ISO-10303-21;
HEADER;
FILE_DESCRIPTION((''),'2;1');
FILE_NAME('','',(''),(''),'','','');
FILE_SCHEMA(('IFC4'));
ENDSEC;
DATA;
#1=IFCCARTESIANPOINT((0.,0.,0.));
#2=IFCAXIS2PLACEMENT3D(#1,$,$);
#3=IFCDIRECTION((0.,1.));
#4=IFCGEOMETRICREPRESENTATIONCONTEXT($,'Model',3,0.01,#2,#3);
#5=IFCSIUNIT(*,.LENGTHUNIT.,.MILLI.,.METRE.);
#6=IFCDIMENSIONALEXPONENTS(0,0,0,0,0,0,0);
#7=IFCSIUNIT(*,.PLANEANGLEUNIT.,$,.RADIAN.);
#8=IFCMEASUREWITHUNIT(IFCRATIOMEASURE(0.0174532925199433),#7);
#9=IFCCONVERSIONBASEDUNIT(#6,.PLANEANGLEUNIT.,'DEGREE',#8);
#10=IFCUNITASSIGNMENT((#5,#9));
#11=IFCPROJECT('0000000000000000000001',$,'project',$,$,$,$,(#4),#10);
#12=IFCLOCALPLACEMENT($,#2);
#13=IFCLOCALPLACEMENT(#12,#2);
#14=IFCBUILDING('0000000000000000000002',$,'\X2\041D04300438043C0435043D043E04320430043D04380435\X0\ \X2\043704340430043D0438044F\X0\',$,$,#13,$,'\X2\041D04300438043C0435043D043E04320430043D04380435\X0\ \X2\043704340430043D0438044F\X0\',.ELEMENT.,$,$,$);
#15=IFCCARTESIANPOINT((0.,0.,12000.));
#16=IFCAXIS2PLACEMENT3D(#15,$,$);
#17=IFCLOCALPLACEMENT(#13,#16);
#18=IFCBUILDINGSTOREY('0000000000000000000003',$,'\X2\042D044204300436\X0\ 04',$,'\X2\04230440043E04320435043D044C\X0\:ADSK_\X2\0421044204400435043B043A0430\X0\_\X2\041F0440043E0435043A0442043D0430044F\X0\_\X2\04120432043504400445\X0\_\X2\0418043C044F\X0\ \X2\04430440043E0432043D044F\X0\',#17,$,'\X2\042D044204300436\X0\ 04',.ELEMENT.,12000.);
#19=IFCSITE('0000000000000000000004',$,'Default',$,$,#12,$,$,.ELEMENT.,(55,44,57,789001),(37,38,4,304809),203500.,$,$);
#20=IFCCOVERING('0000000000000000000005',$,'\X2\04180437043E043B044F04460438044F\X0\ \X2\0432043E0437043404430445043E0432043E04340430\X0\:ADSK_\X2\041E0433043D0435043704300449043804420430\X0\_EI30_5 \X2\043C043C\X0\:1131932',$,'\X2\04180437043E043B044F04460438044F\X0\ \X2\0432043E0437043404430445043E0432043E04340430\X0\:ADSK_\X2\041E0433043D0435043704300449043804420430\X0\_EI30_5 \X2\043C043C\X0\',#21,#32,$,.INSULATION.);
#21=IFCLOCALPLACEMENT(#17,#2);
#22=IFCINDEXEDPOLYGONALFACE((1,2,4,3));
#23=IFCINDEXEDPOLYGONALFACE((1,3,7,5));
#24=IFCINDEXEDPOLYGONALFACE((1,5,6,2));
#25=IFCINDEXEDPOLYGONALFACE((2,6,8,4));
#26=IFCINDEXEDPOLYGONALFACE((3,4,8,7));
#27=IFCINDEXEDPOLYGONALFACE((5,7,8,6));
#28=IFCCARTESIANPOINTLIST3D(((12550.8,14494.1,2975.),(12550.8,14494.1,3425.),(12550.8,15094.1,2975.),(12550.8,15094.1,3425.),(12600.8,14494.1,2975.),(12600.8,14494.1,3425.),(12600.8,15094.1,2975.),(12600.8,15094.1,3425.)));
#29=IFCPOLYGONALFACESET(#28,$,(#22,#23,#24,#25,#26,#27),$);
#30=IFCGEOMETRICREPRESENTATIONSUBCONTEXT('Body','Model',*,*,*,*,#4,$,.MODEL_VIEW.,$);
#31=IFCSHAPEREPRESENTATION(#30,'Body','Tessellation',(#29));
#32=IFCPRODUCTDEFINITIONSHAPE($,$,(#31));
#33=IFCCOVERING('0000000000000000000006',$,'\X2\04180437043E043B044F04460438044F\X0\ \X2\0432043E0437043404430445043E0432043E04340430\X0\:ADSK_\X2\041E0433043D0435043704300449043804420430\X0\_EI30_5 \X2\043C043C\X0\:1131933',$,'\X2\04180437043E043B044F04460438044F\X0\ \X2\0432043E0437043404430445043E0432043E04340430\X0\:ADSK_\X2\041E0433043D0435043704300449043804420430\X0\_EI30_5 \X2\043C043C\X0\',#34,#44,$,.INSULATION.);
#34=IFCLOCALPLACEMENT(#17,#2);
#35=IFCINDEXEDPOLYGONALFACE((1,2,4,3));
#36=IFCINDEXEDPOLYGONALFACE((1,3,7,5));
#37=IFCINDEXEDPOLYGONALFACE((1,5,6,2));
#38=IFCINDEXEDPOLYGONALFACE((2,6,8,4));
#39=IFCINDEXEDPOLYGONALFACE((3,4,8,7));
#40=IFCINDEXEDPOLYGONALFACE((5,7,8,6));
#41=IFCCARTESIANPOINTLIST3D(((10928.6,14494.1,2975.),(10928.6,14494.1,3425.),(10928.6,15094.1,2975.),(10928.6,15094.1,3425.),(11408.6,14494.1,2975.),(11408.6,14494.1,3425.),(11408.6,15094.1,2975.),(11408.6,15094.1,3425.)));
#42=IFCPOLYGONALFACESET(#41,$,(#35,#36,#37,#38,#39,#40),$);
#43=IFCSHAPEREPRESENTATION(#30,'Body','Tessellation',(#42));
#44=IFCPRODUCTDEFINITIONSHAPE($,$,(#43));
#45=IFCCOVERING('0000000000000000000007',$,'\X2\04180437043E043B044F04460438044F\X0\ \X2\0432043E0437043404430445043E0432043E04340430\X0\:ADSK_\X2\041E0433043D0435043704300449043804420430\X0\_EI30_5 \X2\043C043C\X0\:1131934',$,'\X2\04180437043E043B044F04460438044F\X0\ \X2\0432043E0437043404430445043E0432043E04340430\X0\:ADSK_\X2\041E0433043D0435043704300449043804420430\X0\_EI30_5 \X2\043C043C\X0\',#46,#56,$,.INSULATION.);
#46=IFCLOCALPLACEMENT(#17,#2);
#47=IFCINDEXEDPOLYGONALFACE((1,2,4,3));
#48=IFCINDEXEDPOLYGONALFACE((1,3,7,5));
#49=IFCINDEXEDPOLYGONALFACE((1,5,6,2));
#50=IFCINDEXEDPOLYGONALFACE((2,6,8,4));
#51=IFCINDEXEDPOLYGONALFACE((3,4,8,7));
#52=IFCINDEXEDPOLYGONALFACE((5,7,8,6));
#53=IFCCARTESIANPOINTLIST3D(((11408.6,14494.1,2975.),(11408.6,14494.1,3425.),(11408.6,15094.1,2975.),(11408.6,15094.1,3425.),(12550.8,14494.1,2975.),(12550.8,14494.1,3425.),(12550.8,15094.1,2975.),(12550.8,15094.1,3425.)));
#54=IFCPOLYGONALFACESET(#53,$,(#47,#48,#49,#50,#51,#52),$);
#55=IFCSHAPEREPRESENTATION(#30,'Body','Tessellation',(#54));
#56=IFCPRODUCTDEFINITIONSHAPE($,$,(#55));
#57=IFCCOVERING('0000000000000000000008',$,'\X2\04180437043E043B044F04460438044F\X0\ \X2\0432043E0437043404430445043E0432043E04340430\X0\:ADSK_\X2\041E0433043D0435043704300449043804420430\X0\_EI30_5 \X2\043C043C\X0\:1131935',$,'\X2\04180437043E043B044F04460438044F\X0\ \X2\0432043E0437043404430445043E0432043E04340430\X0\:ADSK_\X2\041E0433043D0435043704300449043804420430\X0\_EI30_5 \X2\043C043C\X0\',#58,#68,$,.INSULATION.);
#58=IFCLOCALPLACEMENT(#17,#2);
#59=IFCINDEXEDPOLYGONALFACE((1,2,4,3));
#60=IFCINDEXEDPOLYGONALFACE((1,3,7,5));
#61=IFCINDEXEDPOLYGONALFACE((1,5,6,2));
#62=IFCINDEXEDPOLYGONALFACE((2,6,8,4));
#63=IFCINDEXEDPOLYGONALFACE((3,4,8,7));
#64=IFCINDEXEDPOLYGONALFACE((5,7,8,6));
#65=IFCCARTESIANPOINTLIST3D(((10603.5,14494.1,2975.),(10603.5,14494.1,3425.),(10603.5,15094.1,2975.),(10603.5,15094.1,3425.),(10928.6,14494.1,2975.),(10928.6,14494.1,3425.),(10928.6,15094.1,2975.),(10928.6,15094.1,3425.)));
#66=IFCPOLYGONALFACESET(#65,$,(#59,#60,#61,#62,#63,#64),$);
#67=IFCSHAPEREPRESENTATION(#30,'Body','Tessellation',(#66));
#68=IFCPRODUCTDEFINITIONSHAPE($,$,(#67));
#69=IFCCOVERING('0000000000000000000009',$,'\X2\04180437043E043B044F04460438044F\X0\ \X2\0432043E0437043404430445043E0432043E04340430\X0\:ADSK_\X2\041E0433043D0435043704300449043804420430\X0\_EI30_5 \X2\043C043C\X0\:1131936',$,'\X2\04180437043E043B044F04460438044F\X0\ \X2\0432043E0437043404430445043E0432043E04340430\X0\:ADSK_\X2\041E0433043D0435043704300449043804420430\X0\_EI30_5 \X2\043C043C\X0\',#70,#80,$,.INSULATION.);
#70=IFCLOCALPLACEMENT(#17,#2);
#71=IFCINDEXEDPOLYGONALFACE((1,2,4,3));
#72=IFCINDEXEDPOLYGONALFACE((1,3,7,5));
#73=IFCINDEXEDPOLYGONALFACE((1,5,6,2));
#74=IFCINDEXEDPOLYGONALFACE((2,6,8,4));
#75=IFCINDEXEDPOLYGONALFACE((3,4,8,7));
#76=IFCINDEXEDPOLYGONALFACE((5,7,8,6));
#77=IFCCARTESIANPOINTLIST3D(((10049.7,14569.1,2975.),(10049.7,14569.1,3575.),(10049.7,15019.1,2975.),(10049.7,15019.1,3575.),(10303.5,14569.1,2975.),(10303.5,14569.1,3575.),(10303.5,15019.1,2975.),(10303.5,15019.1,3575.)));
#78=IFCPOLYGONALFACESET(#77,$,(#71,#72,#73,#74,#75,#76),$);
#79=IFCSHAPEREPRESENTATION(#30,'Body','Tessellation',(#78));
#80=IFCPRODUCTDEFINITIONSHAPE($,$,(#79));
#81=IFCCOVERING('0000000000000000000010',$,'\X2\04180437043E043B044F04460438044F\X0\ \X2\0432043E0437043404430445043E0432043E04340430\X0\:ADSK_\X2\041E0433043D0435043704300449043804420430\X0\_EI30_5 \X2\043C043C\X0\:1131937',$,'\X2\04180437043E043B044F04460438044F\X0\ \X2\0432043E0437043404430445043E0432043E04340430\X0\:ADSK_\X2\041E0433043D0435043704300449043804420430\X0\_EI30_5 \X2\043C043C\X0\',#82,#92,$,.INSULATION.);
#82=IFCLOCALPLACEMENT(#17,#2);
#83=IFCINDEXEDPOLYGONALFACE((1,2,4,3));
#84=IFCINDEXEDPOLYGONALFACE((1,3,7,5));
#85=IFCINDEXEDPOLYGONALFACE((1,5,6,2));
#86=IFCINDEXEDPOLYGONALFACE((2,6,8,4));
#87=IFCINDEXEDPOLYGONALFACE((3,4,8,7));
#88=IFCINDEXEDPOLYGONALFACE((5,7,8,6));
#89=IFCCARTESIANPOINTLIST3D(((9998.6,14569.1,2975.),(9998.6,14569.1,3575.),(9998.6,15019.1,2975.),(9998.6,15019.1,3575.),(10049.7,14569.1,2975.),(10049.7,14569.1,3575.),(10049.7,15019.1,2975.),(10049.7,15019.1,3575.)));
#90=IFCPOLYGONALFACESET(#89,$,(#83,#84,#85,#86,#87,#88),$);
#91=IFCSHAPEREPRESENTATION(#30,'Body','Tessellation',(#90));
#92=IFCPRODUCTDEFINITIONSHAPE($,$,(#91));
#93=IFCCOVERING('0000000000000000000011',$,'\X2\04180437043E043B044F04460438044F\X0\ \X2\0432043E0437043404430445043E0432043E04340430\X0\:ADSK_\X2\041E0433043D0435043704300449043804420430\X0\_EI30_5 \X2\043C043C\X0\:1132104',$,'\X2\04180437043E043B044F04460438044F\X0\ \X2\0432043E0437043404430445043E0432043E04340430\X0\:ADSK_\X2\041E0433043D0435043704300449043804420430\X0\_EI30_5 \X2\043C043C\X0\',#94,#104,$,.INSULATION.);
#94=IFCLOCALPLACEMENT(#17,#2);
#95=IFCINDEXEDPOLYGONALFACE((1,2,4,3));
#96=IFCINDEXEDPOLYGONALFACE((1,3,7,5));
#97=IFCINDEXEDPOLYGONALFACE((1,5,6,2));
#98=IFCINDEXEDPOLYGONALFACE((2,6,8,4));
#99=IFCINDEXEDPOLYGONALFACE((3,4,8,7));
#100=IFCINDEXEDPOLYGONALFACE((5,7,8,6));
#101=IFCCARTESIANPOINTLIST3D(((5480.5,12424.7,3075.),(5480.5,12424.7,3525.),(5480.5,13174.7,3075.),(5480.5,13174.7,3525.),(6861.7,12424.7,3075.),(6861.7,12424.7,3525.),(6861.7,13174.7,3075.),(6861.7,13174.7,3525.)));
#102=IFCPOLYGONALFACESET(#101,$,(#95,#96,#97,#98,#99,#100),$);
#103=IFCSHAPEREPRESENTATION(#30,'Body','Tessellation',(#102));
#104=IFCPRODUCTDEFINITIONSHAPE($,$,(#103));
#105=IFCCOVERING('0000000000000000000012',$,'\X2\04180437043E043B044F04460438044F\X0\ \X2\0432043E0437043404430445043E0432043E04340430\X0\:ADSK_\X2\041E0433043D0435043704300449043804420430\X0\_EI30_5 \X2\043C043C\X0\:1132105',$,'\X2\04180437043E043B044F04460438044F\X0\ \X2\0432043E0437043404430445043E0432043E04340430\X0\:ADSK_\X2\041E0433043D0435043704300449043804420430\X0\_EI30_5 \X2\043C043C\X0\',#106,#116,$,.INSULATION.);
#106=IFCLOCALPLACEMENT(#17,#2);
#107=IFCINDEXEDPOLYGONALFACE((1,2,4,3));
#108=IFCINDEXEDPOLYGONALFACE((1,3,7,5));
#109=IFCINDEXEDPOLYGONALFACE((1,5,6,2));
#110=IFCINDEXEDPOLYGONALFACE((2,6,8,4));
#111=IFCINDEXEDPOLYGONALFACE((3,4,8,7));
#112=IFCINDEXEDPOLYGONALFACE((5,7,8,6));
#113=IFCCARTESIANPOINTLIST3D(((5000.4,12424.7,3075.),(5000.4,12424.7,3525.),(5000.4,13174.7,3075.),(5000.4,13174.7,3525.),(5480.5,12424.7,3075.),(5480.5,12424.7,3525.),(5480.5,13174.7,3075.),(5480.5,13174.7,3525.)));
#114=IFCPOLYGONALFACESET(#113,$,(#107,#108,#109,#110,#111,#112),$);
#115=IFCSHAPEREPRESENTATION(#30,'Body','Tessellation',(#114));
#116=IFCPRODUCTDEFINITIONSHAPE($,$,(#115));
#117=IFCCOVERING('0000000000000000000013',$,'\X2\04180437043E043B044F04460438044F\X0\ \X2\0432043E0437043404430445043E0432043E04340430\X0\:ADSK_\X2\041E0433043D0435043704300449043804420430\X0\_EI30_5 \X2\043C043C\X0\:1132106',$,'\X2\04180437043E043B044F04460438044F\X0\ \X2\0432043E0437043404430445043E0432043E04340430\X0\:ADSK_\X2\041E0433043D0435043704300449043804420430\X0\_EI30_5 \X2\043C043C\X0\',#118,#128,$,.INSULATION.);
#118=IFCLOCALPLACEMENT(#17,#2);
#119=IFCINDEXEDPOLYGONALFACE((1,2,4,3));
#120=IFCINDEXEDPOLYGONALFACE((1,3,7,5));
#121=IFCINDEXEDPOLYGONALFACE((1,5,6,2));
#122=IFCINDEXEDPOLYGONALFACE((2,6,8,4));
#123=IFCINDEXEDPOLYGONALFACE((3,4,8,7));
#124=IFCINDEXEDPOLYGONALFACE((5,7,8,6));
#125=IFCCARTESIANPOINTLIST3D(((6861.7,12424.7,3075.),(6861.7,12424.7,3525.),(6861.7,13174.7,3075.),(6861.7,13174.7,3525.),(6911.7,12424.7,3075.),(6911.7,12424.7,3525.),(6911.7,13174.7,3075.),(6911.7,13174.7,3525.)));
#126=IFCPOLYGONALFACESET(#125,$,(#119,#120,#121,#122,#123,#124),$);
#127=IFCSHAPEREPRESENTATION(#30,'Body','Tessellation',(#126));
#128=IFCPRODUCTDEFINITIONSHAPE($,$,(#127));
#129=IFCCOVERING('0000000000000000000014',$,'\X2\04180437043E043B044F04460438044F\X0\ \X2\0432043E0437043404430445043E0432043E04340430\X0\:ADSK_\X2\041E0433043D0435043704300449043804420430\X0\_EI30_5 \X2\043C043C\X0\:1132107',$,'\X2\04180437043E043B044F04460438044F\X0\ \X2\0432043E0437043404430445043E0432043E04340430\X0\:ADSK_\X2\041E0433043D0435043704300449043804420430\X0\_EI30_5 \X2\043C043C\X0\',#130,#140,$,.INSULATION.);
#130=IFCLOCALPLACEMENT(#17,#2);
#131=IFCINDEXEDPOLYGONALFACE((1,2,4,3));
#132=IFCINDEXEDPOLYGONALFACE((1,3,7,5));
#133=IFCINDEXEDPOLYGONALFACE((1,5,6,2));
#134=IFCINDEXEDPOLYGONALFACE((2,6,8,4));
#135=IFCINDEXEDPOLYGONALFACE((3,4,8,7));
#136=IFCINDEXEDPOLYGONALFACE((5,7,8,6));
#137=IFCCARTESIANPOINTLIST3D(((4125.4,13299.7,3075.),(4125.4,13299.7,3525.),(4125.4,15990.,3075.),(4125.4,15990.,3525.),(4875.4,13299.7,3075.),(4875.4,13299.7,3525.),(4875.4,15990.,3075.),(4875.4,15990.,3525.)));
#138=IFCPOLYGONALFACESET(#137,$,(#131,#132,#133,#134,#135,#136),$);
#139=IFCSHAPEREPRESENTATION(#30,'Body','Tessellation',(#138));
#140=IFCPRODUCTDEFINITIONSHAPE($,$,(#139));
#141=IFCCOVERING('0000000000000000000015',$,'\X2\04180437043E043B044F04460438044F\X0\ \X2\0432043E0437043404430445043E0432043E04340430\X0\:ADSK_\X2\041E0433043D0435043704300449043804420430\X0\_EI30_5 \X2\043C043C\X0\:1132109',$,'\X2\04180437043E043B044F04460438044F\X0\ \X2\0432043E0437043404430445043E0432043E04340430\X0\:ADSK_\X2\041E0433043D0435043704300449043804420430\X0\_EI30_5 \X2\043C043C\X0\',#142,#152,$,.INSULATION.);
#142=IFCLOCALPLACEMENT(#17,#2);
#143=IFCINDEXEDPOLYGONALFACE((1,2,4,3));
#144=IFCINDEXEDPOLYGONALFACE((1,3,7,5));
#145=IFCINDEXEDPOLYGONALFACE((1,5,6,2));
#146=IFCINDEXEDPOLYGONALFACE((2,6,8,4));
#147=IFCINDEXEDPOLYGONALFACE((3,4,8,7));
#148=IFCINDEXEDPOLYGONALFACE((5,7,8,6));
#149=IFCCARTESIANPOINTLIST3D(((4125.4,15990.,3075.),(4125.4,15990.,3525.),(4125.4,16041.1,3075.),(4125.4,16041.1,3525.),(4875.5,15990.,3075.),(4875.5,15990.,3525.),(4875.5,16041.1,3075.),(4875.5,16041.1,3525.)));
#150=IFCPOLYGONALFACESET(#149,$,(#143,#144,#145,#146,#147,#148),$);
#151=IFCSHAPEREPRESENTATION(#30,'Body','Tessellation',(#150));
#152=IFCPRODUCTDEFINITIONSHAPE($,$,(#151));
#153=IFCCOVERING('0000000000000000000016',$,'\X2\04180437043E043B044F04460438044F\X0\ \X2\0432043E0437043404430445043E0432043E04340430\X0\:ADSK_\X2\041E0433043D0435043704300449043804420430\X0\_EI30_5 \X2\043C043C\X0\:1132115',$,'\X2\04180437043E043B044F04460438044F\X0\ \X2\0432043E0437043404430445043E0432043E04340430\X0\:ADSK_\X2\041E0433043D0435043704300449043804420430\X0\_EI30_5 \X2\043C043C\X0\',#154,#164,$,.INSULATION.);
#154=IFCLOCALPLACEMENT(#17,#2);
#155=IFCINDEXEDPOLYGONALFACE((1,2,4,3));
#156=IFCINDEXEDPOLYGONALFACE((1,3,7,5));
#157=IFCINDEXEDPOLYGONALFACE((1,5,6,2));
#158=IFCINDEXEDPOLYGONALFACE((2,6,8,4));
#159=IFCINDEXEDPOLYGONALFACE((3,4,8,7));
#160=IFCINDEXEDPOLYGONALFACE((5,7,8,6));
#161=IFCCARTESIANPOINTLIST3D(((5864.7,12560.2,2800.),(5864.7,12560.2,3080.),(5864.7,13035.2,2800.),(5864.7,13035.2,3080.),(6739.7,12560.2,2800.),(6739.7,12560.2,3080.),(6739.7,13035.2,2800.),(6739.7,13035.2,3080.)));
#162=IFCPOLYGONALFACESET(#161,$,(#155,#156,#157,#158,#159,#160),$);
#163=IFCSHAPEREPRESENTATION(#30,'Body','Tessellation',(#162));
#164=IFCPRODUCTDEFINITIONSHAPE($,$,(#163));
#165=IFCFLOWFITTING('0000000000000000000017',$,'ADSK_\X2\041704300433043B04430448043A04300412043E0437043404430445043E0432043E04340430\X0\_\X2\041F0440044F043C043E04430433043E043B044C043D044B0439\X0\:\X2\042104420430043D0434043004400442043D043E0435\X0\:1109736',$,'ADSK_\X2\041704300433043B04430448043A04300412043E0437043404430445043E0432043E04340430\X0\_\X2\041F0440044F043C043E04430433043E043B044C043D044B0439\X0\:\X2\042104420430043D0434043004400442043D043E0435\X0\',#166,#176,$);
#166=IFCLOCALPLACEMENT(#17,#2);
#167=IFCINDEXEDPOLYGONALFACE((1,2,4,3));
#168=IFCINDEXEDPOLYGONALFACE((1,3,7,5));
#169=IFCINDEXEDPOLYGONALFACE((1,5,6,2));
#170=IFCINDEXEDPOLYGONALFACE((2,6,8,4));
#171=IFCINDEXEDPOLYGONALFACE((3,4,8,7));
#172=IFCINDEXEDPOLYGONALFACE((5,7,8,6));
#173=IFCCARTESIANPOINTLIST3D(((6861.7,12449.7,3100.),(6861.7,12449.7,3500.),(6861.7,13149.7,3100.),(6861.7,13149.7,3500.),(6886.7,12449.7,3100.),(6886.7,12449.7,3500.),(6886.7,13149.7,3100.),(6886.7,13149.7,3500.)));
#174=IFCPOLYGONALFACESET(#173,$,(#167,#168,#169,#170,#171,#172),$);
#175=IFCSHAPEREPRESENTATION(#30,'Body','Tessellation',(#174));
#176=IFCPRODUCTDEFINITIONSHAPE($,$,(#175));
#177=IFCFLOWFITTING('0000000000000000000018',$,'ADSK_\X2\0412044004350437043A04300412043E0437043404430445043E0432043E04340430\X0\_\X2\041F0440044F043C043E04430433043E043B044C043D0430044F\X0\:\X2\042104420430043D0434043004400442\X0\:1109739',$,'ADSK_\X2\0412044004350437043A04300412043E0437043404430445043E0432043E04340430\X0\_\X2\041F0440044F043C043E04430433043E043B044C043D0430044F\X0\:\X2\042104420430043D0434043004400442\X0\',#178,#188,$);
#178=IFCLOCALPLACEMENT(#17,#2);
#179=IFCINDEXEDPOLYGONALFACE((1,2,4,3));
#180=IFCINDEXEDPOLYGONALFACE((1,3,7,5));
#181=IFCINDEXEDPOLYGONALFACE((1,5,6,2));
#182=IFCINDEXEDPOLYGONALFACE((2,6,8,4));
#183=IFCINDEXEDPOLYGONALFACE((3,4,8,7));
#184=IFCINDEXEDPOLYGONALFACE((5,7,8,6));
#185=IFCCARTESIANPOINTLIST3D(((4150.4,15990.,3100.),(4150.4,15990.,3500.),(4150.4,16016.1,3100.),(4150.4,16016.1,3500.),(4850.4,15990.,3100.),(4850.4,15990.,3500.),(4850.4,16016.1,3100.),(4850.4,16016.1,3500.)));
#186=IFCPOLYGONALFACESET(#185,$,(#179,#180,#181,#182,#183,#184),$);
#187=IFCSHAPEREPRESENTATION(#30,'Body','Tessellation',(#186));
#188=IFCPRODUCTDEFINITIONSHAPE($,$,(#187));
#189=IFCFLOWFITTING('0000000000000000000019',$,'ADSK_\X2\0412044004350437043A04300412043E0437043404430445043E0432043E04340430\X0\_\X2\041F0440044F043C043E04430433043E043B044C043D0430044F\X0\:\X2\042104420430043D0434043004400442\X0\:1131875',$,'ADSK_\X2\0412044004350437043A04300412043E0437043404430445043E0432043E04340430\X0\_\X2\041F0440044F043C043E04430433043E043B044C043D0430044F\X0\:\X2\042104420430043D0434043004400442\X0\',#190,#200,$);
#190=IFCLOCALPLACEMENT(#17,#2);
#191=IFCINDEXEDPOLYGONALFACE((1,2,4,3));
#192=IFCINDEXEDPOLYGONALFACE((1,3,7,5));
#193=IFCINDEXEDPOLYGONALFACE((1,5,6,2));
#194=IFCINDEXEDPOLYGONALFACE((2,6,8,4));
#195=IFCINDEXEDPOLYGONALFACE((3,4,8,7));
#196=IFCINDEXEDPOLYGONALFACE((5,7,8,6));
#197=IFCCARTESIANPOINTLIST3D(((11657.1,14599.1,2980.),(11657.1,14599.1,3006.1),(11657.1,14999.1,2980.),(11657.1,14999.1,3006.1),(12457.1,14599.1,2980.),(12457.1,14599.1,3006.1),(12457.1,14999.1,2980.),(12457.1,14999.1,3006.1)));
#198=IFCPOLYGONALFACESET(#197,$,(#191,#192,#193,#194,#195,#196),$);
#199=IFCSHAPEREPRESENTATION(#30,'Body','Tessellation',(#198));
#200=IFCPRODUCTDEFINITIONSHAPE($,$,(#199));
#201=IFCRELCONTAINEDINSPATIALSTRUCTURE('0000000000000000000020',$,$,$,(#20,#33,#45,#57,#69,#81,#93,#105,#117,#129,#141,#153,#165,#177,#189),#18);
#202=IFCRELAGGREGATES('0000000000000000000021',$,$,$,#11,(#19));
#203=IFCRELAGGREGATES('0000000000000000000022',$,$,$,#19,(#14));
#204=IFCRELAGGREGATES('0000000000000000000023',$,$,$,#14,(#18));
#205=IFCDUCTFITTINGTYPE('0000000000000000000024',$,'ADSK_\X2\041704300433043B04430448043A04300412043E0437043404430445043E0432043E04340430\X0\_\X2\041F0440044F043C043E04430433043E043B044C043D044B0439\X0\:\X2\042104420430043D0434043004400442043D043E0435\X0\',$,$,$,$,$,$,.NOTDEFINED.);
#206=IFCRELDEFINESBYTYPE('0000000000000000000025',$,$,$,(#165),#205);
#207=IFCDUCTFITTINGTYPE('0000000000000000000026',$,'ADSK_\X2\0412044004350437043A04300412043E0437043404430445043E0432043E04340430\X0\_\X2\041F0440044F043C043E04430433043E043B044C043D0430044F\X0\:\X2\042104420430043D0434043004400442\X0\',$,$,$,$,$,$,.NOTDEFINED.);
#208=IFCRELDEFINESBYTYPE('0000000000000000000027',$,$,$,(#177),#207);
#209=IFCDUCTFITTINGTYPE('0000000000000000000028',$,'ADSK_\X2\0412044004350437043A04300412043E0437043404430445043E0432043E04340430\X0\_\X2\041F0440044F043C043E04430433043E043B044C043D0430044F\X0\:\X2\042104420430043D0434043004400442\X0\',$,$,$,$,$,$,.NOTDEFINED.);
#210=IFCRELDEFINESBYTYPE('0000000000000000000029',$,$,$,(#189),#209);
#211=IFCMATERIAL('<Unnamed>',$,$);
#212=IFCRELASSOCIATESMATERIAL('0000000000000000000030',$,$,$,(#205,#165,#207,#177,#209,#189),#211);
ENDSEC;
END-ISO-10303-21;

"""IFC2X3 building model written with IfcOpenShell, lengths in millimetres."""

from ifc_helpers import new_model, entity, si_unit, converted_unit, direction, frame, origin, origin_2d_with_axis, place, context, subcontext, project, spatial, rectangle, extrude, source, transform, mapped, material, type_object, type_shapes, element, save


model = new_model("IFC2X3")

# Units and contexts
model_context = context("Model", 3, precision=0.01, world=origin(), true_north=direction((0.0, 1.0)))
body_context = subcontext(model_context, "Body", "Model", "MODEL_VIEW")
ifc_project = project(units=[si_unit("LENGTHUNIT", "METRE", prefix="MILLI"), converted_unit("PLANEANGLEUNIT", "DEGREE", entity("IfcRatioMeasure", 0.0174532925199433), si_unit("PLANEANGLEUNIT", "RADIAN"), dimensions=[0, 0, 0, 0, 0, 0, 0])], contexts=[model_context])

# Site, building, storey
site_placement = place(None, origin())
site = spatial("IfcSite", under=ifc_project, at=site_placement, Name="Default", CompositionType="ELEMENT", RefLatitude=(55, 44, 57, 789001), RefLongitude=(37, 38, 4, 304809), RefElevation=203500.0)
building_placement = place(site_placement, origin())
building = spatial("IfcBuilding", under=site, at=building_placement, Name="Наименование здания", LongName="Наименование здания", CompositionType="ELEMENT")
storey_placement = place(building_placement, frame((0.0, 0.0, 12000.0)))
storey = spatial("IfcBuildingStorey", under=building, at=storey_placement, Name="Этаж 04", ObjectType="Уровень:ADSK_Стрелка_Проектная_Вверх_Имя уровня", LongName="Этаж 04", CompositionType="ELEMENT", Elevation=12000.0)

# Coverings
covering_1_placement = place(storey_placement, frame((12550.8, 14494.1, 2975.0)))
element("IfcCovering", 1, at=covering_1_placement, inside=storey, Name="Изоляция воздуховода:ADSK_Огнезащита_EI30_5 мм:1131932", ObjectType="Изоляция воздуховода:ADSK_Огнезащита_EI30_5 мм", PredefinedType="INSULATION", context=body_context, shape_type="SweptSolid", body=[
    extrude(rectangle(XDim=50.0, YDim=600.0, at=origin_2d_with_axis()), frame((25.0, 300.0, 0.0), z_axis=(0.0, 0.0, 1.0), x_axis=(-1.0, 0.0, 0.0)), (0.0, 0.0, 1.0), 450.0),
])
covering_2_placement = place(storey_placement, frame((10928.6, 14494.1, 2975.0)))
element("IfcCovering", 2, at=covering_2_placement, inside=storey, Name="Изоляция воздуховода:ADSK_Огнезащита_EI30_5 мм:1131933", ObjectType="Изоляция воздуховода:ADSK_Огнезащита_EI30_5 мм", PredefinedType="INSULATION", context=body_context, shape_type="SweptSolid", body=[
    extrude(rectangle(XDim=480.0, YDim=600.0, at=origin_2d_with_axis()), frame((240.0, 300.0, 0.0), z_axis=(0.0, 0.0, 1.0), x_axis=(-1.0, 0.0, 0.0)), (0.0, 0.0, 1.0), 450.0),
])
covering_3_placement = place(storey_placement, frame((11408.6, 14494.1, 2975.0)))
element("IfcCovering", 3, at=covering_3_placement, inside=storey, Name="Изоляция воздуховода:ADSK_Огнезащита_EI30_5 мм:1131934", ObjectType="Изоляция воздуховода:ADSK_Огнезащита_EI30_5 мм", PredefinedType="INSULATION", context=body_context, shape_type="SweptSolid", body=[
    extrude(rectangle(XDim=1142.1, YDim=600.0, at=origin_2d_with_axis()), frame((571.1, 300.0, 0.0), z_axis=(0.0, 0.0, 1.0), x_axis=(-1.0, 0.0, 0.0)), (0.0, 0.0, 1.0), 450.0),
])
covering_4_placement = place(storey_placement, frame((10603.5, 14494.1, 2975.0)))
element("IfcCovering", 4, at=covering_4_placement, inside=storey, Name="Изоляция воздуховода:ADSK_Огнезащита_EI30_5 мм:1131935", ObjectType="Изоляция воздуховода:ADSK_Огнезащита_EI30_5 мм", PredefinedType="INSULATION", context=body_context, shape_type="SweptSolid", body=[
    extrude(rectangle(XDim=325.1, YDim=600.0, at=origin_2d_with_axis()), frame((162.6, 300.0, 0.0), z_axis=(0.0, 0.0, 1.0), x_axis=(-1.0, 0.0, 0.0)), (0.0, 0.0, 1.0), 450.0),
])
covering_5_placement = place(storey_placement, frame((10049.7, 14569.1, 2975.0)))
element("IfcCovering", 5, at=covering_5_placement, inside=storey, Name="Изоляция воздуховода:ADSK_Огнезащита_EI30_5 мм:1131936", ObjectType="Изоляция воздуховода:ADSK_Огнезащита_EI30_5 мм", PredefinedType="INSULATION", context=body_context, shape_type="SweptSolid", body=[
    extrude(rectangle(XDim=253.8, YDim=450.0, at=origin_2d_with_axis()), frame((126.9, 225.0, 0.0), z_axis=(0.0, 0.0, 1.0), x_axis=(-1.0, 0.0, 0.0)), (0.0, 0.0, 1.0), 600.0),
])
covering_6_placement = place(storey_placement, frame((9998.6, 14569.1, 2975.0)))
element("IfcCovering", 6, at=covering_6_placement, inside=storey, Name="Изоляция воздуховода:ADSK_Огнезащита_EI30_5 мм:1131937", ObjectType="Изоляция воздуховода:ADSK_Огнезащита_EI30_5 мм", PredefinedType="INSULATION", context=body_context, shape_type="SweptSolid", body=[
    extrude(rectangle(XDim=450.0, YDim=51.1, at=origin_2d_with_axis()), frame((25.6, 225.0, 0.0), z_axis=(0.0, 0.0, 1.0), x_axis=(0.0, 1.0, 0.0)), (0.0, 0.0, 1.0), 600.0),
])
covering_7_placement = place(storey_placement, frame((5480.4, 12424.7, 3075.0)))
element("IfcCovering", 7, at=covering_7_placement, inside=storey, Name="Изоляция воздуховода:ADSK_Огнезащита_EI30_5 мм:1132104", ObjectType="Изоляция воздуховода:ADSK_Огнезащита_EI30_5 мм", PredefinedType="INSULATION", context=body_context, shape_type="SweptSolid", body=[
    extrude(rectangle(XDim=1381.3, YDim=750.0, at=origin_2d_with_axis()), frame((690.6, 375.0, 0.0)), (0.0, 0.0, 1.0), 450.0),
])
covering_8_placement = place(storey_placement, frame((5000.4, 12424.7, 3075.0)))
element("IfcCovering", 8, at=covering_8_placement, inside=storey, Name="Изоляция воздуховода:ADSK_Огнезащита_EI30_5 мм:1132105", ObjectType="Изоляция воздуховода:ADSK_Огнезащита_EI30_5 мм", PredefinedType="INSULATION", context=body_context, shape_type="SweptSolid", body=[
    extrude(rectangle(XDim=480.0, YDim=750.0, at=origin_2d_with_axis()), frame((240.0, 375.0, 0.0)), (0.0, 0.0, 1.0), 450.0),
])
covering_9_placement = place(storey_placement, frame((6861.7, 12424.7, 3075.0)))
element("IfcCovering", 9, at=covering_9_placement, inside=storey, Name="Изоляция воздуховода:ADSK_Огнезащита_EI30_5 мм:1132106", ObjectType="Изоляция воздуховода:ADSK_Огнезащита_EI30_5 мм", PredefinedType="INSULATION", context=body_context, shape_type="SweptSolid", body=[
    extrude(rectangle(XDim=50.0, YDim=750.0, at=origin_2d_with_axis()), frame((25.0, 375.0, 0.0), z_axis=(0.0, 0.0, 1.0), x_axis=(-1.0, 0.0, 0.0)), (0.0, 0.0, 1.0), 450.0),
])
covering_10_placement = place(storey_placement, frame((4125.4, 13299.7, 3075.0)))
element("IfcCovering", 10, at=covering_10_placement, inside=storey, Name="Изоляция воздуховода:ADSK_Огнезащита_EI30_5 мм:1132107", ObjectType="Изоляция воздуховода:ADSK_Огнезащита_EI30_5 мм", PredefinedType="INSULATION", context=body_context, shape_type="SweptSolid", body=[
    extrude(rectangle(XDim=2690.3, YDim=750.0, at=origin_2d_with_axis()), frame((375.0, 1345.2, 0.0), z_axis=(0.0, 0.0, 1.0), x_axis=(0.0, 1.0, 0.0)), (0.0, 0.0, 1.0), 450.0),
])
covering_11_placement = place(storey_placement, frame((4125.4, 15990.0, 3075.0)))
element("IfcCovering", 11, at=covering_11_placement, inside=storey, Name="Изоляция воздуховода:ADSK_Огнезащита_EI30_5 мм:1132109", ObjectType="Изоляция воздуховода:ADSK_Огнезащита_EI30_5 мм", PredefinedType="INSULATION", context=body_context, shape_type="SweptSolid", body=[
    extrude(rectangle(XDim=750.0, YDim=51.1, at=origin_2d_with_axis()), frame((375.0, 25.6, 0.0)), (0.0, 0.0, 1.0), 450.0),
])
covering_12_placement = place(storey_placement, frame((5864.7, 12560.2, 2800.0)))
element("IfcCovering", 12, at=covering_12_placement, inside=storey, Name="Изоляция воздуховода:ADSK_Огнезащита_EI30_5 мм:1132115", ObjectType="Изоляция воздуховода:ADSK_Огнезащита_EI30_5 мм", PredefinedType="INSULATION", context=body_context, shape_type="SweptSolid", body=[
    extrude(rectangle(XDim=875.0, YDim=475.0, at=origin_2d_with_axis()), frame((437.5, 237.5, 0.0), z_axis=(0.0, 0.0, 1.0), x_axis=(-1.0, 0.0, 0.0)), (0.0, 0.0, 1.0), 280.0),
])

# Flow fittings
ifc_material_1 = material(Name="<Unnamed>")
duct_fitting_type_1 = type_object("IfcDuctFittingType", Name="ADSK_ЗаглушкаВоздуховода_Прямоугольный:Стандартное", PredefinedType="NOTDEFINED", material=ifc_material_1)
shared_shape_1 = source(origin(), body_context, "Body", "SweptSolid", [
    extrude(rectangle(XDim=25.0, YDim=700.0, at=origin_2d_with_axis()), frame((12.5, 0.0, -200.0)), (0.0, 0.0, 1.0), 400.0),
])
type_shapes(duct_fitting_type_1, [shared_shape_1])
flow_fitting_1_placement = place(storey_placement, frame((6861.7, 12799.7, 3300.0)))
element("IfcFlowFitting", 13, at=flow_fitting_1_placement, inside=storey, type_object=duct_fitting_type_1, material=ifc_material_1, Name="ADSK_ЗаглушкаВоздуховода_Прямоугольный:Стандартное:1109736", ObjectType="ADSK_ЗаглушкаВоздуховода_Прямоугольный:Стандартное", context=body_context, shape_type="MappedRepresentation", body=[
    mapped(shared_shape_1, transform((0.0, 0.0, 0.0), scale=1.0)),
])
duct_fitting_type_2 = type_object("IfcDuctFittingType", Name="ADSK_ВрезкаВоздуховода_Прямоугольная:Стандарт", PredefinedType="NOTDEFINED", material=ifc_material_1)
shared_shape_2 = source(origin(), body_context, "Body", "SweptSolid", [
    extrude(rectangle(XDim=26.1, YDim=400.0, at=origin_2d_with_axis()), frame((7.0, 0.0, -350.0)), (0.0, 0.0, 1.0), 700.0),
])
type_shapes(duct_fitting_type_2, [shared_shape_2])
flow_fitting_2_placement = place(storey_placement, frame((4500.4, 16010.0, 3300.0), z_axis=(-1.0, 0.0, 0.0), x_axis=(0.0, -1.0, 0.0)))
element("IfcFlowFitting", 14, at=flow_fitting_2_placement, inside=storey, type_object=duct_fitting_type_2, material=ifc_material_1, Name="ADSK_ВрезкаВоздуховода_Прямоугольная:Стандарт:1109739", ObjectType="ADSK_ВрезкаВоздуховода_Прямоугольная:Стандарт", context=body_context, shape_type="MappedRepresentation", body=[
    mapped(shared_shape_2, transform((0.0, 0.0, 0.0), scale=1.0)),
])
duct_fitting_type_3 = type_object("IfcDuctFittingType", Name="ADSK_ВрезкаВоздуховода_Прямоугольная:Стандарт", PredefinedType="NOTDEFINED", material=ifc_material_1)
shared_shape_3 = source(origin(), body_context, "Body", "SweptSolid", [
    extrude(rectangle(XDim=800.0, YDim=26.1, at=origin_2d_with_axis()), frame((7.0, 0.0, -200.0), z_axis=(0.0, 0.0, 1.0), x_axis=(0.0, -1.0, 0.0)), (0.0, 0.0, 1.0), 400.0),
])
type_shapes(duct_fitting_type_3, [shared_shape_3])
flow_fitting_3_placement = place(storey_placement, frame((12057.1, 14799.1, 3000.0), z_axis=(0.0, 1.0, 0.0), x_axis=(0.0, 0.0, -1.0)))
element("IfcFlowFitting", 15, at=flow_fitting_3_placement, inside=storey, type_object=duct_fitting_type_3, material=ifc_material_1, Name="ADSK_ВрезкаВоздуховода_Прямоугольная:Стандарт:1131875", ObjectType="ADSK_ВрезкаВоздуховода_Прямоугольная:Стандарт", context=body_context, shape_type="MappedRepresentation", body=[
    mapped(shared_shape_3, transform((0.0, 0.0, 0.0), scale=1.0)),
])

save(model, "model.ifc")
